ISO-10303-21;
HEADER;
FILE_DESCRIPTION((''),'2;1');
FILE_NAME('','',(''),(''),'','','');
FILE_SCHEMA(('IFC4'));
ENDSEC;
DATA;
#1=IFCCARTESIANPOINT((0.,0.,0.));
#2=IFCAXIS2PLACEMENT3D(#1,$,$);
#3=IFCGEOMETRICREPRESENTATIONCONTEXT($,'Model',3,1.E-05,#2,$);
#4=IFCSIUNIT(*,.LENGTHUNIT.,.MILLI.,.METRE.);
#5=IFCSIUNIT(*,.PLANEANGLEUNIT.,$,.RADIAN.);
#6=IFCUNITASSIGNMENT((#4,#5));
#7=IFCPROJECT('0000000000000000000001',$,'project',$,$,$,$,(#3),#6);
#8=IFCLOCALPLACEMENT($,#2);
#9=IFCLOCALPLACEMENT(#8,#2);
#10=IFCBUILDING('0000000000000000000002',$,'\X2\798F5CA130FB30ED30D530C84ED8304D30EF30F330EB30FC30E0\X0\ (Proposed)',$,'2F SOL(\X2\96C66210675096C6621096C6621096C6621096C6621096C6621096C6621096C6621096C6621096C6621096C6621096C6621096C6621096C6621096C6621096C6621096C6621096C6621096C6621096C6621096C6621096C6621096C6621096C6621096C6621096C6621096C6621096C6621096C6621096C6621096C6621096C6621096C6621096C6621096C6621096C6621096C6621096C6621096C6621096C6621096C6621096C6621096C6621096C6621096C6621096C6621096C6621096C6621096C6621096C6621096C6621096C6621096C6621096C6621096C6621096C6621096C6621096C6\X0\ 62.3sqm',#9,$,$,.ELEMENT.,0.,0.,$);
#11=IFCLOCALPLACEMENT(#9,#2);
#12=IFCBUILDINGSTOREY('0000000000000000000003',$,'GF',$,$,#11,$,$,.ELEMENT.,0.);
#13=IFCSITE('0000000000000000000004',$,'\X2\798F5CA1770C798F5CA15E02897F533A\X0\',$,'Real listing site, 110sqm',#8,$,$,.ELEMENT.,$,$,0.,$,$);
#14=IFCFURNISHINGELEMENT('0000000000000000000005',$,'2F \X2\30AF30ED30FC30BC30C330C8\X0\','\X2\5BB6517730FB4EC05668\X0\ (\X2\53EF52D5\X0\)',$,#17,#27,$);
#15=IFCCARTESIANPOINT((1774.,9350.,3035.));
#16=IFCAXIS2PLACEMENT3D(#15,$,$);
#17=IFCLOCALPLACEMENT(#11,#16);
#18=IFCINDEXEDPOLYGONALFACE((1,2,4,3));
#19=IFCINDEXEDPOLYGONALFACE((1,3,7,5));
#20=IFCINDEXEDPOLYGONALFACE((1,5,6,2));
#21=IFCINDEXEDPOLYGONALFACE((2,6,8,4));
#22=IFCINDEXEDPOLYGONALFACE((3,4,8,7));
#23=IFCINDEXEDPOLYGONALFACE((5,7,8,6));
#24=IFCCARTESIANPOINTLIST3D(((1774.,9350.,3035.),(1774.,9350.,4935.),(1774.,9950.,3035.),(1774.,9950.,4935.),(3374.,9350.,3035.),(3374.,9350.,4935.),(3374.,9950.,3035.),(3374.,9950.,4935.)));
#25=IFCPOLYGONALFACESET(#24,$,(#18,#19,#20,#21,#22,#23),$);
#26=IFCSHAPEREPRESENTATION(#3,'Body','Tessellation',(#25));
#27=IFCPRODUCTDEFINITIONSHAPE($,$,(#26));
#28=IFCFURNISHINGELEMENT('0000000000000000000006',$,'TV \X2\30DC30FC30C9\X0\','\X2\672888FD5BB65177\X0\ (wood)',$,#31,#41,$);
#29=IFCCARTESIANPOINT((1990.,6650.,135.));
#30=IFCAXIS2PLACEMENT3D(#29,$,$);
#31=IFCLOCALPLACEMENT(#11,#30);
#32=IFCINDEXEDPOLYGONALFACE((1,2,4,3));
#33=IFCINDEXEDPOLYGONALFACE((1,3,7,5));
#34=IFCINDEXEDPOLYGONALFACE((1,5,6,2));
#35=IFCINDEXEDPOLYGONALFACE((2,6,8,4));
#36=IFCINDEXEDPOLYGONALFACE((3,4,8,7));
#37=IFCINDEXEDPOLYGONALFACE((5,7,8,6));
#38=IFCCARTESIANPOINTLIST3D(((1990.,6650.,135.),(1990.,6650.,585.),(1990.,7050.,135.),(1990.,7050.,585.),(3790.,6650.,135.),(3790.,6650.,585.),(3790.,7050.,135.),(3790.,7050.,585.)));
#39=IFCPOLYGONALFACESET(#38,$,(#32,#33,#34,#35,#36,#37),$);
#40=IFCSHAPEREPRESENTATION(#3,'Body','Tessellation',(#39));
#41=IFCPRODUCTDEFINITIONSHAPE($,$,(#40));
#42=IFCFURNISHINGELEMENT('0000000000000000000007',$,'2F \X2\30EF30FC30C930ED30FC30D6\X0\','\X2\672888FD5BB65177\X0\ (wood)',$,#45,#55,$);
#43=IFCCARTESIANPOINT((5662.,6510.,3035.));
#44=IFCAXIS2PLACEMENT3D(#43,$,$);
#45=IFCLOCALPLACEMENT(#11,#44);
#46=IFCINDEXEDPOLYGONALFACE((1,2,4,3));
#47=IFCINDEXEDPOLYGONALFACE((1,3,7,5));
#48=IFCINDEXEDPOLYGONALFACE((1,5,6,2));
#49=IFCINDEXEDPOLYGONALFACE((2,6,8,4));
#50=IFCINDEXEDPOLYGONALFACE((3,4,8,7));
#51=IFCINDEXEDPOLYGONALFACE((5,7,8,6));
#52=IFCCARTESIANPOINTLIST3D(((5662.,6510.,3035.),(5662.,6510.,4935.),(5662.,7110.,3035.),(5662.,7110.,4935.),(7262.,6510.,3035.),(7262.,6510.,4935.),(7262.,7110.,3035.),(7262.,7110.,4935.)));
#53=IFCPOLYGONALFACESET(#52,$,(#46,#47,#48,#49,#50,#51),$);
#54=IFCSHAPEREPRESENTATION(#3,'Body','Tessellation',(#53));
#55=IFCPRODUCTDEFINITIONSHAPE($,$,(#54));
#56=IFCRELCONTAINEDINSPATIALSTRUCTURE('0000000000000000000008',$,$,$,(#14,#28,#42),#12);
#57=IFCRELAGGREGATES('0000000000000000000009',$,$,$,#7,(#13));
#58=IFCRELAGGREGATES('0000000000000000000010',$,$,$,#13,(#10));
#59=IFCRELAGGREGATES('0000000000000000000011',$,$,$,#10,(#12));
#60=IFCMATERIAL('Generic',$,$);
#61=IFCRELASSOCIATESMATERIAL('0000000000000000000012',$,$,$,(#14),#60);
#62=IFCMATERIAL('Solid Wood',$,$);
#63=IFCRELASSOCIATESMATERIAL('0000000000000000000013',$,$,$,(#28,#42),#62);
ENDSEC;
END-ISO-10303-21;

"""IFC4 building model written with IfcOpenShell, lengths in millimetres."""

from ifc_helpers import new_model, si_unit, frame, frame_2d, origin, place, context, project, spatial, rectangle, extrude, material, element, save


model = new_model("IFC4")

# Units and contexts
model_context = context("Model", 3, precision=1e-05, world=origin())
ifc_project = project(units=[si_unit("LENGTHUNIT", "METRE", prefix="MILLI"), si_unit("PLANEANGLEUNIT", "RADIAN")], contexts=[model_context])

# Site, building, storey
site_placement = place(None, origin())
site = spatial("IfcSite", under=ifc_project, at=site_placement, Name="福岡県福岡市西区", ObjectType="Real listing site, 110sqm", CompositionType="ELEMENT", RefElevation=0.0)
building_placement = place(site_placement, origin())
building = spatial("IfcBuilding", under=site, at=building_placement, Name="福岡・ロフト付きワンルーム (Proposed)", ObjectType="2F SOL(集成材集成集成集成集成集成集成集成集成集成集成集成集成集成集成集成集成集成集成集成集成集成集成集成集成集成集成集成集成集成集成集成集成集成集成集成集成集成集成集成集成集成集成集成集成集成集成集成集成集成集成集成集成集成集成集成集成集 62.3sqm", CompositionType="ELEMENT", ElevationOfRefHeight=0.0, ElevationOfTerrain=0.0)
storey_placement = place(building_placement, origin())
storey = spatial("IfcBuildingStorey", under=building, at=storey_placement, Name="GF", CompositionType="ELEMENT", Elevation=0.0)

# Shared definitions
ifc_material_1 = material(Name="Solid Wood")

# Shared definitions
ifc_material_2 = material(Name="Generic")

# Furnishing elements
furnishing_1_placement = place(storey_placement, frame((1774.0, 9350.0, 3035.0)))
element("IfcFurnishingElement", 1, at=furnishing_1_placement, inside=storey, material=ifc_material_2, Name="2F クローゼット", Description="家具・什器 (可動)", context=model_context, shape_type="SweptSolid", body=[
    extrude(rectangle(XDim=1600.0, YDim=600.0, at=frame_2d((800.0, 300.0))), frame((1774.0, 9350.0, 3035.0)), (0.0, 0.0, 1.0), 1900.0),
])
furnishing_2_placement = place(storey_placement, frame((1990.0, 6650.0, 135.0)))
element("IfcFurnishingElement", 2, at=furnishing_2_placement, inside=storey, material=ifc_material_1, Name="TV ボード", Description="木製家具 (wood)", context=model_context, shape_type="SweptSolid", body=[
    extrude(rectangle(XDim=1800.0, YDim=400.0, at=frame_2d((900.0, 200.0))), frame((1990.0, 6650.0, 135.0)), (0.0, 0.0, 1.0), 450.0),
])
furnishing_3_placement = place(storey_placement, frame((5662.0, 6510.0, 3035.0)))
element("IfcFurnishingElement", 3, at=furnishing_3_placement, inside=storey, material=ifc_material_1, Name="2F ワードローブ", Description="木製家具 (wood)", context=model_context, shape_type="SweptSolid", body=[
    extrude(rectangle(XDim=1600.0, YDim=600.0, at=frame_2d((800.0, 300.0))), frame((5662.0, 6510.0, 3035.0)), (0.0, 0.0, 1.0), 1900.0),
])

save(model, "model.ifc")
